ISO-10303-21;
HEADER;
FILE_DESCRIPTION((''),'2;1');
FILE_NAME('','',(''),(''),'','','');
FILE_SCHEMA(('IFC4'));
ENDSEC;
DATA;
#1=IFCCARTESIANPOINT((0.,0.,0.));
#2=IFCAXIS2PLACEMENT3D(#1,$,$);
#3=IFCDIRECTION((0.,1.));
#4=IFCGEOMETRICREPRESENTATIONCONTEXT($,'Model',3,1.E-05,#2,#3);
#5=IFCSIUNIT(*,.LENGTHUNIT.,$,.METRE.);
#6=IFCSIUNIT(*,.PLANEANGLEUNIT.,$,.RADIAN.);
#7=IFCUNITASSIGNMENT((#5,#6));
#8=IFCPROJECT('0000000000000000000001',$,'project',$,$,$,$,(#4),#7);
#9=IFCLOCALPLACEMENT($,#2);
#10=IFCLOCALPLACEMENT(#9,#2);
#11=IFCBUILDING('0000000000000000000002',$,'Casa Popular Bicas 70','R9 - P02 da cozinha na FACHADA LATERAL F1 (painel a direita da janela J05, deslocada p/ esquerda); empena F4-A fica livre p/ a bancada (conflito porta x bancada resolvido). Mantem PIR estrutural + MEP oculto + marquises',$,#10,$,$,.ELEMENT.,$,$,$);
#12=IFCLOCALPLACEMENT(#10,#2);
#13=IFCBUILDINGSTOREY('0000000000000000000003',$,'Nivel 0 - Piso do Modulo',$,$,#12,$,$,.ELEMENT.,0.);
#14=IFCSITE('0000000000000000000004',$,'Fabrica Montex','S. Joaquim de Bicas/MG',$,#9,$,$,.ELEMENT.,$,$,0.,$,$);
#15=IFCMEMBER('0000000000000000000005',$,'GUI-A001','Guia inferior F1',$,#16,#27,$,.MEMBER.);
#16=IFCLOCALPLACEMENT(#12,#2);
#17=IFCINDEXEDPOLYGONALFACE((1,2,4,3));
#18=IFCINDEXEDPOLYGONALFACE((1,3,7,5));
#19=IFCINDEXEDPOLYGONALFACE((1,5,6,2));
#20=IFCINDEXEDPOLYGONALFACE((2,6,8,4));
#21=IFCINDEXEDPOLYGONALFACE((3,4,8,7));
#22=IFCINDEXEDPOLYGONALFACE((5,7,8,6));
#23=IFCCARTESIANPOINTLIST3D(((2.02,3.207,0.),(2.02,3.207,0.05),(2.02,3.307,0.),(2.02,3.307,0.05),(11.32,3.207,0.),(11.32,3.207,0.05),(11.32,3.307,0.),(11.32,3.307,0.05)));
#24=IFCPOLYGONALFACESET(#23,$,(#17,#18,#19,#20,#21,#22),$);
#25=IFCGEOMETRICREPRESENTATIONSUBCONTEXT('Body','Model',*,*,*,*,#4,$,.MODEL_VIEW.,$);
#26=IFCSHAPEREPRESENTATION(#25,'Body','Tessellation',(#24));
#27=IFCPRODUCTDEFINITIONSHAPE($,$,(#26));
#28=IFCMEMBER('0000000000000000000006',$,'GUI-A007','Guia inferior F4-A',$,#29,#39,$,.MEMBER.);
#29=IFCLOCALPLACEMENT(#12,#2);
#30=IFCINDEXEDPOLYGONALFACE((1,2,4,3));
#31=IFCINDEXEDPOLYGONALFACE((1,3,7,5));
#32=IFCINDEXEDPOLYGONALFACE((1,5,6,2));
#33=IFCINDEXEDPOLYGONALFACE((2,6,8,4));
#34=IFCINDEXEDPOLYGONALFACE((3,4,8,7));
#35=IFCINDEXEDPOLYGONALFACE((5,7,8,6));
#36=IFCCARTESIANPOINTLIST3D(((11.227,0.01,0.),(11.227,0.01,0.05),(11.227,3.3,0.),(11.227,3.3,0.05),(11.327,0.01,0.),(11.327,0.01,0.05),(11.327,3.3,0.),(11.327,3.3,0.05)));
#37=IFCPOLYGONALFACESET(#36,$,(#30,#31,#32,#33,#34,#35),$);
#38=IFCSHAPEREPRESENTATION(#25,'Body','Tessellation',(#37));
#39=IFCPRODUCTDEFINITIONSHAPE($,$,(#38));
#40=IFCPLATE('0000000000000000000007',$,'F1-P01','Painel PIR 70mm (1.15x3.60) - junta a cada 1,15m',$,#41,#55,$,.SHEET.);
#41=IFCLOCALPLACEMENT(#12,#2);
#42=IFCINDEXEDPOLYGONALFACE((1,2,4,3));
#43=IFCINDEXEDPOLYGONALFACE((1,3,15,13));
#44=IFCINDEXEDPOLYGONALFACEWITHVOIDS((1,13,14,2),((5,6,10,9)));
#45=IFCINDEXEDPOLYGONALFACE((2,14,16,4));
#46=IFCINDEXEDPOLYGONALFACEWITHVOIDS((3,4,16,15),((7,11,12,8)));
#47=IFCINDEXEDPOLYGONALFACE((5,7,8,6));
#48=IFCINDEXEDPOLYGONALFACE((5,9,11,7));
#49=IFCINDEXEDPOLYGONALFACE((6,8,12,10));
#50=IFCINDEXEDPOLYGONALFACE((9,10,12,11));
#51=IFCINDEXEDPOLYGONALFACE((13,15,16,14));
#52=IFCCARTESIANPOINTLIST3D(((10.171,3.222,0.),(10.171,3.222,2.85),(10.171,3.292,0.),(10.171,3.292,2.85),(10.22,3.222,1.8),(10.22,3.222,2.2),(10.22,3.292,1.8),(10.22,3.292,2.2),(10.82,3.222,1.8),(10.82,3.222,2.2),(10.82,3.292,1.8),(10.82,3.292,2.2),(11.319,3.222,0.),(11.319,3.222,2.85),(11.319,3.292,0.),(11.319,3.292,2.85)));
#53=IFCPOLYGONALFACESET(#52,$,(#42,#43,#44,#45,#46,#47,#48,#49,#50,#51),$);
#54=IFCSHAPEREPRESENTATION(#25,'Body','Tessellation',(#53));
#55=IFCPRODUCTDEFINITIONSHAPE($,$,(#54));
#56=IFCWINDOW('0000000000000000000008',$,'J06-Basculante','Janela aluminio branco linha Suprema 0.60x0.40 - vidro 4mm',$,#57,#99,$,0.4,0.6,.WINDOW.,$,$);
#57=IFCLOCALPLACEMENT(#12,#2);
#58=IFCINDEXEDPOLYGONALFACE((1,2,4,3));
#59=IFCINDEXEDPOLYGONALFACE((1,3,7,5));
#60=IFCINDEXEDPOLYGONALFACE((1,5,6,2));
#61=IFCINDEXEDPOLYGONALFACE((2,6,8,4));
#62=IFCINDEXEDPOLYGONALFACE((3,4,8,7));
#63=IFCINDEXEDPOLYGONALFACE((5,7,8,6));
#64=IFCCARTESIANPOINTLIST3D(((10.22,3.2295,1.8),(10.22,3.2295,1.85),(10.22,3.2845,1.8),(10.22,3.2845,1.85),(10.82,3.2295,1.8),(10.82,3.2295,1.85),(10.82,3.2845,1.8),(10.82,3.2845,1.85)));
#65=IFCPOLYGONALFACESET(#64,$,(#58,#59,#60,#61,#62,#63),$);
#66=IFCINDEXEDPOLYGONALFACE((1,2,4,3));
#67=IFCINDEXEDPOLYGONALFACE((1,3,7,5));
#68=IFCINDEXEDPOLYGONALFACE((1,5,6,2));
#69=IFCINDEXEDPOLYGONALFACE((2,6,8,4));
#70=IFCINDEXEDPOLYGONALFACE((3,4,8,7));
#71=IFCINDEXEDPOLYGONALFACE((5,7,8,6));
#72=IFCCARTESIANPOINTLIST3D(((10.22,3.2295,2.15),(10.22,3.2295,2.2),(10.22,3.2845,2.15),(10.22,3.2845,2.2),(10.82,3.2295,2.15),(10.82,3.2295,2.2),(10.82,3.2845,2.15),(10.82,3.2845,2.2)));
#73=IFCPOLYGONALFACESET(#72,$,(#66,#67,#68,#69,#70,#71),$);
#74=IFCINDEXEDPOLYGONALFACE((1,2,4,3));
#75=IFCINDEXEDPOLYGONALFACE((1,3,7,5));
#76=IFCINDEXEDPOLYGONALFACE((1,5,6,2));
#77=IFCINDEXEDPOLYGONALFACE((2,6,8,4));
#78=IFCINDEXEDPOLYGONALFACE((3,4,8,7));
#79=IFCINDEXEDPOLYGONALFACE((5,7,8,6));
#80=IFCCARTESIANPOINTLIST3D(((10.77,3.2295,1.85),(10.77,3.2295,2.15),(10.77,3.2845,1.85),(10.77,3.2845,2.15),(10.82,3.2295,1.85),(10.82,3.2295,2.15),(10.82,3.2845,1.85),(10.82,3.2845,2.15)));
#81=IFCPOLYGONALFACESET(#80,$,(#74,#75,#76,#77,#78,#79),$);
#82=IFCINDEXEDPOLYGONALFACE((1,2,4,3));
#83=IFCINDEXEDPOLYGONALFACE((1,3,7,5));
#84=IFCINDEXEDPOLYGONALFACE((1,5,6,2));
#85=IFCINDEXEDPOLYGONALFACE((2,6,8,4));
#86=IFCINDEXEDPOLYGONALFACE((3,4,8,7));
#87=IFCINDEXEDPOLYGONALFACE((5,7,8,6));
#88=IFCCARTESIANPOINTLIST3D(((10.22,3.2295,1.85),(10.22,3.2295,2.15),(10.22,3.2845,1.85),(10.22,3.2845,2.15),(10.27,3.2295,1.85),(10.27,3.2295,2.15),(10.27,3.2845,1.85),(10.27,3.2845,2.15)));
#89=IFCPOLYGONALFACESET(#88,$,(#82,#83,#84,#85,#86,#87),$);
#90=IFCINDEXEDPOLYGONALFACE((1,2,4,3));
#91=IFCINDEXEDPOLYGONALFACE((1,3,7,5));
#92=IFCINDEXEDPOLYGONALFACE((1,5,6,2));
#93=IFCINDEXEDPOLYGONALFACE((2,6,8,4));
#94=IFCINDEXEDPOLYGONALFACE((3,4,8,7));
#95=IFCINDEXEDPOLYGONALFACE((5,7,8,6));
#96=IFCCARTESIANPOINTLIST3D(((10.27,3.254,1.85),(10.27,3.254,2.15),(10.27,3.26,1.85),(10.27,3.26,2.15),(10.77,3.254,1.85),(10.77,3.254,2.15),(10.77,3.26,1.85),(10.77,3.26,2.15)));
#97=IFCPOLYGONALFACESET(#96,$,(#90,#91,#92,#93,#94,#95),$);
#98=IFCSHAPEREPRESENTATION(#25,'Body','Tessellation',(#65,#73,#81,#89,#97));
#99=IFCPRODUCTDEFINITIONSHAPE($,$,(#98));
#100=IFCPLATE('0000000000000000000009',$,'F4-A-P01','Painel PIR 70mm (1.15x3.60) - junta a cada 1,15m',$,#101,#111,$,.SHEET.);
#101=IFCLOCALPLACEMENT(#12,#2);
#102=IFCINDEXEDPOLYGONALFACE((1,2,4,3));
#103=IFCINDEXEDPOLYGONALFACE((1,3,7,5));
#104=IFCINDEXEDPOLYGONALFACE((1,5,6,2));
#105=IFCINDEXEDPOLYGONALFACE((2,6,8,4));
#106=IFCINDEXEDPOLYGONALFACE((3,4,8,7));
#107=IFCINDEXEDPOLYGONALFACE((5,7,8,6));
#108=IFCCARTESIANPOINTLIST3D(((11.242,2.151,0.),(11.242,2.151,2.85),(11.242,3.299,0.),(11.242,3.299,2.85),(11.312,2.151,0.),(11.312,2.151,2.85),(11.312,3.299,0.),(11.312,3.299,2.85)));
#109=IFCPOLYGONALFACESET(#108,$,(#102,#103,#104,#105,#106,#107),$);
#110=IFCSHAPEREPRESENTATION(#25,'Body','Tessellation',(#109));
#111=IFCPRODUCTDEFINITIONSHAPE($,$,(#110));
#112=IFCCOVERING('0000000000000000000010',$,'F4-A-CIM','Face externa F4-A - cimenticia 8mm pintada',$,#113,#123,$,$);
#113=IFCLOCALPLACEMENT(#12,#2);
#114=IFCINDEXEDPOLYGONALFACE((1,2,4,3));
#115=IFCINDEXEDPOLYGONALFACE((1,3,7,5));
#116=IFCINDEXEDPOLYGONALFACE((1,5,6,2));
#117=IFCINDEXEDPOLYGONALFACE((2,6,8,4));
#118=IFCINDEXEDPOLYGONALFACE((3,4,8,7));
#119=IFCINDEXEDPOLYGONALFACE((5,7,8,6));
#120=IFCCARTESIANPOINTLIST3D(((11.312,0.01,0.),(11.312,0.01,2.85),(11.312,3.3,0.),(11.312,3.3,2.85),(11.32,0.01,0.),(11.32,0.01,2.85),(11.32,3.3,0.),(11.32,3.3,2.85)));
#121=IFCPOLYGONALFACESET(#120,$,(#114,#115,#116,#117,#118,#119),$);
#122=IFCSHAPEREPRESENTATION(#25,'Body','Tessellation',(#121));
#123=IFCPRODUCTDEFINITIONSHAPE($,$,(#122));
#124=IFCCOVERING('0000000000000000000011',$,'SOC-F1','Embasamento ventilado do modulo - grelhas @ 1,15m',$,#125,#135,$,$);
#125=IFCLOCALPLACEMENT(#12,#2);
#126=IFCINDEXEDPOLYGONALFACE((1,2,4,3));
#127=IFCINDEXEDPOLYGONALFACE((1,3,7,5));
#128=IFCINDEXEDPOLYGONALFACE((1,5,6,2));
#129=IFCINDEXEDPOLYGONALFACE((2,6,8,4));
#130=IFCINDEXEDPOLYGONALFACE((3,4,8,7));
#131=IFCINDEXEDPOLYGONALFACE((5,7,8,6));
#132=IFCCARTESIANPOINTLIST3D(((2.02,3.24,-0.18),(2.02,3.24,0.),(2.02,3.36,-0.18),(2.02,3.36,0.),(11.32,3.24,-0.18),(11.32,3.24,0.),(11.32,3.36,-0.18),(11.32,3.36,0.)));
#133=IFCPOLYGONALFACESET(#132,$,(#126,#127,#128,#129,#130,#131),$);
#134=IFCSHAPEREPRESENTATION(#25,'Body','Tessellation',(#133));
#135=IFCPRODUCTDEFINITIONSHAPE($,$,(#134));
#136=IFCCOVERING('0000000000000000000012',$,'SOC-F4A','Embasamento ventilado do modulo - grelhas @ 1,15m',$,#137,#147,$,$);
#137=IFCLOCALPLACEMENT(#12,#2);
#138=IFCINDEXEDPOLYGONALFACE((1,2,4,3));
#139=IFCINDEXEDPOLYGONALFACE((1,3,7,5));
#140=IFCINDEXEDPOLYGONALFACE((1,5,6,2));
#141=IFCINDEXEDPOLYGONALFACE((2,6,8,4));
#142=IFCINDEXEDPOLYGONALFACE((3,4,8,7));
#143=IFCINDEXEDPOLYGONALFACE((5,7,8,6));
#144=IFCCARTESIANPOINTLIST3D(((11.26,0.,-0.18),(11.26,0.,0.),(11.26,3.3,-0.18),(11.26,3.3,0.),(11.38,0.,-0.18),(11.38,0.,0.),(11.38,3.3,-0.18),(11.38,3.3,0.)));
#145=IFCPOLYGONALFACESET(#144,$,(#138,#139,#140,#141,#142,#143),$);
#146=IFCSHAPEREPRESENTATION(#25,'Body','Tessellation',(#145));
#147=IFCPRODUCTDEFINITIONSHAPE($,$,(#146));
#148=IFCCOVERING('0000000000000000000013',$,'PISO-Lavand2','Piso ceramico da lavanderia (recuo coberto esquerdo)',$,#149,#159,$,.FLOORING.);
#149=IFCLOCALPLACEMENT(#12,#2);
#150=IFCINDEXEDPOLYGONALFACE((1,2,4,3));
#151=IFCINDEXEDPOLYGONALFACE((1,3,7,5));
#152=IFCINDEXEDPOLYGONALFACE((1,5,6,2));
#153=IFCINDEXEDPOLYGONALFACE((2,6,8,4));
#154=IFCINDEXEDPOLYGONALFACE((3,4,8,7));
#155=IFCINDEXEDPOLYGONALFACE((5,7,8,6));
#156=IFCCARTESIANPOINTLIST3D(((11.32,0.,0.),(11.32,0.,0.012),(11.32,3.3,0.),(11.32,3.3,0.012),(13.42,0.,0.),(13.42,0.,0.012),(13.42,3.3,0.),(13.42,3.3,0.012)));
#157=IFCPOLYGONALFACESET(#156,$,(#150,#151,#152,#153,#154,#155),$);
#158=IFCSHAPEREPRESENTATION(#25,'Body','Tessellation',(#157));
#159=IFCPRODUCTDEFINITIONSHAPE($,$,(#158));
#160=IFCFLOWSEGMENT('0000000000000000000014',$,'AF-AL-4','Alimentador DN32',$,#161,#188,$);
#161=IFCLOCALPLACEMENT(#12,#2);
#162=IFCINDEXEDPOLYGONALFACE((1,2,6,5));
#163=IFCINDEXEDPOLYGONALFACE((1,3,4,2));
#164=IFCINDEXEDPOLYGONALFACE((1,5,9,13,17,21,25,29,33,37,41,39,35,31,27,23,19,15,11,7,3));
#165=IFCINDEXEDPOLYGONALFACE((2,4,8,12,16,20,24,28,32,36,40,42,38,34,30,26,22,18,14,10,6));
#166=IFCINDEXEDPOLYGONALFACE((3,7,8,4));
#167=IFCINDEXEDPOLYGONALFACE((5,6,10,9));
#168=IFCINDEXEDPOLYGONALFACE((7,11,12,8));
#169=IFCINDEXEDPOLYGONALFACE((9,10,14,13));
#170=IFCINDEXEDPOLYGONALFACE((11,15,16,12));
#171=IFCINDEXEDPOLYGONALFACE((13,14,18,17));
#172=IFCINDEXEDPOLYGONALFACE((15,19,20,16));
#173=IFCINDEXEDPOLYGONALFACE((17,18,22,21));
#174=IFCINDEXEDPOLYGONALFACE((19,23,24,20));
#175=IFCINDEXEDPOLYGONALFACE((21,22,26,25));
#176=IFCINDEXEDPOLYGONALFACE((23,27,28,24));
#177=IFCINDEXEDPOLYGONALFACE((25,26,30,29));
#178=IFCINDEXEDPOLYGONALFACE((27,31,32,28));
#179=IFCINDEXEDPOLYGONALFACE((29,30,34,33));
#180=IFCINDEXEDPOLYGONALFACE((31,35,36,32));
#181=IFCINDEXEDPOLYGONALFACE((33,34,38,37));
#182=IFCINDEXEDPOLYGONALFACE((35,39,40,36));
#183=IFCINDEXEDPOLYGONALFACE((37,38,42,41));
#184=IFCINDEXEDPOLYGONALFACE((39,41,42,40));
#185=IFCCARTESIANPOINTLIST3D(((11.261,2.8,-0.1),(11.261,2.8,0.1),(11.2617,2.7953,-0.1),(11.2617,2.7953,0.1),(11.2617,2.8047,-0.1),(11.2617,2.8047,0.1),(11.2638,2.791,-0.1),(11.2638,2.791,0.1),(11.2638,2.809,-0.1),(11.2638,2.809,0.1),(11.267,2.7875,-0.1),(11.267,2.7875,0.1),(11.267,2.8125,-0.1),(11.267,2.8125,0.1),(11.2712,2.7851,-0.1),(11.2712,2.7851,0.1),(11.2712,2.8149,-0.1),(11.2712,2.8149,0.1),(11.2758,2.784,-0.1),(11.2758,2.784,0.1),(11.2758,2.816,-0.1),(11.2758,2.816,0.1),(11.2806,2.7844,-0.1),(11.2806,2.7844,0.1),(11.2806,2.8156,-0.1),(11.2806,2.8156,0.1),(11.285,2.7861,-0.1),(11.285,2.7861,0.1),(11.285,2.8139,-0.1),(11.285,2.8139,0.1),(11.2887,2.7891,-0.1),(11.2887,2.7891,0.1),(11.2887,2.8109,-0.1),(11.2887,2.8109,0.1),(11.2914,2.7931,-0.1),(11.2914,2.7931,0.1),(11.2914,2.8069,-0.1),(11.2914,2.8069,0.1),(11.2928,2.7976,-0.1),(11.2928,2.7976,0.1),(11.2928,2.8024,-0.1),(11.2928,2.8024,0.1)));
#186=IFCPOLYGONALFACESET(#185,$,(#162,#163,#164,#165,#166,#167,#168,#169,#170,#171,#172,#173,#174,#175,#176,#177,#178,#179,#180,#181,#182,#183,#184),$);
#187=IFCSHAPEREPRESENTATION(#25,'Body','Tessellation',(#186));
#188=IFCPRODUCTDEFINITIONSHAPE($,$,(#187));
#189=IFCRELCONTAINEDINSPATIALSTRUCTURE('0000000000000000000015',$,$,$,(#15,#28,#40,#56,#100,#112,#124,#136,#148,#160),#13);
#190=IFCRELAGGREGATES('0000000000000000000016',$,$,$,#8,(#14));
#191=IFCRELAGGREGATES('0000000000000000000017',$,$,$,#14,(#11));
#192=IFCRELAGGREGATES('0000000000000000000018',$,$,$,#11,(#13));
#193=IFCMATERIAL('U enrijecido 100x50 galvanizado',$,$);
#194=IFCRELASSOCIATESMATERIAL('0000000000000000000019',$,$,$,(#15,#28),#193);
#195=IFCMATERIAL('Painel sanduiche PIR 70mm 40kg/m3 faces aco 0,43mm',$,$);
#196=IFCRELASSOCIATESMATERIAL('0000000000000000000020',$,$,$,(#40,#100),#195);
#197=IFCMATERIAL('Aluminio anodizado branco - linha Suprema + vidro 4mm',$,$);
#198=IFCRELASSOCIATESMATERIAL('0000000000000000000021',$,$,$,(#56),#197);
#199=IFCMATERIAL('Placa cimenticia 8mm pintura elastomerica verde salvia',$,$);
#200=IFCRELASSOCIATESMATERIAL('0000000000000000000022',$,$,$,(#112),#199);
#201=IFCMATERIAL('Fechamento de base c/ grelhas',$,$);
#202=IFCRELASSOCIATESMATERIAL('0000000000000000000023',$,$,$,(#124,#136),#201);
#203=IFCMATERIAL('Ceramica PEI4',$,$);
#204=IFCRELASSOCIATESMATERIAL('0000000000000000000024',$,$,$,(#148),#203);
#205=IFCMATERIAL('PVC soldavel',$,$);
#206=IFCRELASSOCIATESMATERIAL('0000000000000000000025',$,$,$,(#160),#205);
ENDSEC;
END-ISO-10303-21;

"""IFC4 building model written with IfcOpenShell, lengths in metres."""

from ifc_helpers import new_model, si_unit, direction, frame, frame_2d, origin, origin_2d, place, context, subcontext, project, spatial, rectangle, circle, extrude, material, element, fill, save


model = new_model("IFC4")

# Units and contexts
model_context = context("Model", 3, precision=1e-05, world=origin(), true_north=direction((0.0, 1.0)))
body_context = subcontext(model_context, "Body", "Model", "MODEL_VIEW")
ifc_project = project(units=[si_unit("LENGTHUNIT", "METRE"), si_unit("PLANEANGLEUNIT", "RADIAN")], contexts=[model_context])

# Site, building, storey
site_placement = place(None, origin())
site = spatial("IfcSite", under=ifc_project, at=site_placement, Name="Fabrica Montex", Description="S. Joaquim de Bicas/MG", CompositionType="ELEMENT", RefElevation=0.0)
building_placement = place(site_placement, origin())
building = spatial("IfcBuilding", under=site, at=building_placement, Name="Casa Popular Bicas 70", Description="R9 - P02 da cozinha na FACHADA LATERAL F1 (painel a direita da janela J05, deslocada p/ esquerda); empena F4-A fica livre p/ a bancada (conflito porta x bancada resolvido). Mantem PIR estrutural + MEP oculto + marquises", CompositionType="ELEMENT")
storey_placement = place(building_placement, origin())
storey = spatial("IfcBuildingStorey", under=building, at=storey_placement, Name="Nivel 0 - Piso do Modulo", CompositionType="ELEMENT", Elevation=0.0)

# Members
ifc_material_1 = material(Name="U enrijecido 100x50 galvanizado")
member_1_placement = place(None, frame((11.32, 3.257, 0.025), z_axis=(-1.0, 0.0, 0.0), x_axis=(0.0, 0.0, 1.0)))
element("IfcMember", 1, at=member_1_placement, inside=storey, material=ifc_material_1, Name="GUI-A001", Description="Guia inferior F1", PredefinedType="MEMBER", context=body_context, shape_type="SweptSolid", body=[
    extrude(rectangle(XDim=0.05, YDim=0.1, at=origin_2d()), origin(), (0.0, 0.0, 1.0), 9.3),
])
member_2_placement = place(None, frame((11.277, 3.3, 0.025), z_axis=(0.0, -1.0, 0.0), x_axis=(0.0, 0.0, 1.0)))
element("IfcMember", 2, at=member_2_placement, inside=storey, material=ifc_material_1, Name="GUI-A007", Description="Guia inferior F4-A", PredefinedType="MEMBER", context=body_context, shape_type="SweptSolid", body=[
    extrude(rectangle(XDim=0.05, YDim=0.1, at=origin_2d()), origin(), (0.0, 0.0, 1.0), 3.29),
])

# Plate, opening, window
ifc_material_2 = material(Name="Painel sanduiche PIR 70mm 40kg/m3 faces aco 0,43mm")
plate_1_placement = place(None, frame((11.319, 3.257, 0.0), z_axis=(0.0, 0.0, 1.0), x_axis=(-1.0, 0.0, 0.0)))
plate_1 = element("IfcPlate", 3, at=plate_1_placement, inside=storey, material=ifc_material_2, Name="F1-P01", Description="Painel PIR 70mm (1.15x3.60) - junta a cada 1,15m", PredefinedType="SHEET", context=body_context, shape_type="SweptSolid", body=[
    extrude(rectangle(XDim=1.148, YDim=0.07, at=frame_2d((0.574, 0.0))), origin(), (0.0, 0.0, 1.0), 2.85),
])
opening_1_placement = place(None, frame((10.52, 3.257, 1.8), z_axis=(0.0, 0.0, 1.0), x_axis=(-1.0, 0.0, 0.0)))
opening_1 = element("IfcOpeningElement", 4, at=opening_1_placement, cuts=plate_1, PredefinedType="OPENING", context=body_context, shape_type="SweptSolid", body=[
    extrude(rectangle(XDim=0.6, YDim=0.1, at=origin_2d()), origin(), (0.0, 0.0, 1.0), 0.4),
])
ifc_material_3 = material(Name="Aluminio anodizado branco - linha Suprema + vidro 4mm")
window_placement = place(None, frame((10.82, 3.257, 1.8), z_axis=(0.0, 0.0, 1.0), x_axis=(-1.0, 0.0, 0.0)))
window = element("IfcWindow", 5, at=window_placement, inside=storey, material=ifc_material_3, Name="J06-Basculante", Description="Janela aluminio branco linha Suprema 0.60x0.40 - vidro 4mm", OverallHeight=0.4, OverallWidth=0.6, PredefinedType="WINDOW", context=body_context, shape_type="SweptSolid", body=[
    extrude(rectangle(XDim=0.6, YDim=0.055, at=frame_2d((0.3, 0.0))), origin(), (0.0, 0.0, 1.0), 0.05),
    extrude(rectangle(XDim=0.6, YDim=0.055, at=frame_2d((0.3, 0.0))), frame((0.0, 0.0, 0.35)), (0.0, 0.0, 1.0), 0.05),
    extrude(rectangle(XDim=0.05, YDim=0.055, at=frame_2d((0.025, 0.0))), frame((0.0, 0.0, 0.05)), (0.0, 0.0, 1.0), 0.3),
    extrude(rectangle(XDim=0.05, YDim=0.055, at=frame_2d((0.575, 0.0))), frame((0.0, 0.0, 0.05)), (0.0, 0.0, 1.0), 0.3),
    extrude(rectangle(XDim=0.5, YDim=0.006, at=frame_2d((0.3, 0.0))), frame((0.0, 0.0, 0.05)), (0.0, 0.0, 1.0), 0.3),
])
fill(opening_1, window)

# Plate
plate_2_placement = place(None, frame((11.277, 3.299, 0.0), z_axis=(0.0, 0.0, 1.0), x_axis=(0.0, -1.0, 0.0)))
element("IfcPlate", 6, at=plate_2_placement, inside=storey, material=ifc_material_2, Name="F4-A-P01", Description="Painel PIR 70mm (1.15x3.60) - junta a cada 1,15m", PredefinedType="SHEET", context=body_context, shape_type="SweptSolid", body=[
    extrude(rectangle(XDim=1.148, YDim=0.07, at=frame_2d((0.574, 0.0))), origin(), (0.0, 0.0, 1.0), 2.85),
])

# Shared definitions
ifc_material_4 = material(Name="Placa cimenticia 8mm pintura elastomerica verde salvia")

# Coverings
covering_1_placement = place(None, frame((11.316, 3.3, 0.0), z_axis=(0.0, 0.0, 1.0), x_axis=(0.0, -1.0, 0.0)))
element("IfcCovering", 7, at=covering_1_placement, inside=storey, material=ifc_material_4, Name="F4-A-CIM", Description="Face externa F4-A - cimenticia 8mm pintada", context=body_context, shape_type="SweptSolid", body=[
    extrude(rectangle(XDim=3.29, YDim=0.008, at=frame_2d((1.645, 0.0))), origin(), (0.0, 0.0, 1.0), 2.85),
])
ifc_material_5 = material(Name="Fechamento de base c/ grelhas")
covering_2_placement = place(None, frame((11.32, 3.3, -0.18), z_axis=(0.0, 0.0, 1.0), x_axis=(-1.0, 0.0, 0.0)))
element("IfcCovering", 8, at=covering_2_placement, inside=storey, material=ifc_material_5, Name="SOC-F1", Description="Embasamento ventilado do modulo - grelhas @ 1,15m", context=body_context, shape_type="SweptSolid", body=[
    extrude(rectangle(XDim=9.3, YDim=0.12, at=frame_2d((4.65, 0.0))), origin(), (0.0, 0.0, 1.0), 0.18),
])
covering_3_placement = place(None, frame((11.32, 3.3, -0.18), z_axis=(0.0, 0.0, 1.0), x_axis=(0.0, -1.0, 0.0)))
element("IfcCovering", 9, at=covering_3_placement, inside=storey, material=ifc_material_5, Name="SOC-F4A", Description="Embasamento ventilado do modulo - grelhas @ 1,15m", context=body_context, shape_type="SweptSolid", body=[
    extrude(rectangle(XDim=3.3, YDim=0.12, at=frame_2d((1.65, 0.0))), origin(), (0.0, 0.0, 1.0), 0.18),
])
ifc_material_6 = material(Name="Ceramica PEI4")
covering_4_placement = place(None, frame((13.42, 3.3, 0.0), z_axis=(0.0, 0.0, 1.0), x_axis=(-1.0, 0.0, 0.0)))
element("IfcCovering", 10, at=covering_4_placement, inside=storey, material=ifc_material_6, Name="PISO-Lavand2", Description="Piso ceramico da lavanderia (recuo coberto esquerdo)", PredefinedType="FLOORING", context=body_context, shape_type="SweptSolid", body=[
    extrude(rectangle(XDim=2.1, YDim=3.3, at=frame_2d((1.05, 1.65))), origin(), (0.0, 0.0, 1.0), 0.012),
])

# Flow segment
ifc_material_7 = material(Name="PVC soldavel")
flow_segment_1_placement = place(None, frame((11.277, 2.8, -0.1), z_axis=(0.0, 0.0, 1.0), x_axis=(-1.0, 0.0, 0.0)))
element("IfcFlowSegment", 11, at=flow_segment_1_placement, inside=storey, material=ifc_material_7, Name="AF-AL-4", Description="Alimentador DN32", context=body_context, shape_type="SweptSolid", body=[
    extrude(circle(Radius=0.016, at=origin_2d()), origin(), (0.0, 0.0, 1.0), 0.2),
])

save(model, "model.ifc")
